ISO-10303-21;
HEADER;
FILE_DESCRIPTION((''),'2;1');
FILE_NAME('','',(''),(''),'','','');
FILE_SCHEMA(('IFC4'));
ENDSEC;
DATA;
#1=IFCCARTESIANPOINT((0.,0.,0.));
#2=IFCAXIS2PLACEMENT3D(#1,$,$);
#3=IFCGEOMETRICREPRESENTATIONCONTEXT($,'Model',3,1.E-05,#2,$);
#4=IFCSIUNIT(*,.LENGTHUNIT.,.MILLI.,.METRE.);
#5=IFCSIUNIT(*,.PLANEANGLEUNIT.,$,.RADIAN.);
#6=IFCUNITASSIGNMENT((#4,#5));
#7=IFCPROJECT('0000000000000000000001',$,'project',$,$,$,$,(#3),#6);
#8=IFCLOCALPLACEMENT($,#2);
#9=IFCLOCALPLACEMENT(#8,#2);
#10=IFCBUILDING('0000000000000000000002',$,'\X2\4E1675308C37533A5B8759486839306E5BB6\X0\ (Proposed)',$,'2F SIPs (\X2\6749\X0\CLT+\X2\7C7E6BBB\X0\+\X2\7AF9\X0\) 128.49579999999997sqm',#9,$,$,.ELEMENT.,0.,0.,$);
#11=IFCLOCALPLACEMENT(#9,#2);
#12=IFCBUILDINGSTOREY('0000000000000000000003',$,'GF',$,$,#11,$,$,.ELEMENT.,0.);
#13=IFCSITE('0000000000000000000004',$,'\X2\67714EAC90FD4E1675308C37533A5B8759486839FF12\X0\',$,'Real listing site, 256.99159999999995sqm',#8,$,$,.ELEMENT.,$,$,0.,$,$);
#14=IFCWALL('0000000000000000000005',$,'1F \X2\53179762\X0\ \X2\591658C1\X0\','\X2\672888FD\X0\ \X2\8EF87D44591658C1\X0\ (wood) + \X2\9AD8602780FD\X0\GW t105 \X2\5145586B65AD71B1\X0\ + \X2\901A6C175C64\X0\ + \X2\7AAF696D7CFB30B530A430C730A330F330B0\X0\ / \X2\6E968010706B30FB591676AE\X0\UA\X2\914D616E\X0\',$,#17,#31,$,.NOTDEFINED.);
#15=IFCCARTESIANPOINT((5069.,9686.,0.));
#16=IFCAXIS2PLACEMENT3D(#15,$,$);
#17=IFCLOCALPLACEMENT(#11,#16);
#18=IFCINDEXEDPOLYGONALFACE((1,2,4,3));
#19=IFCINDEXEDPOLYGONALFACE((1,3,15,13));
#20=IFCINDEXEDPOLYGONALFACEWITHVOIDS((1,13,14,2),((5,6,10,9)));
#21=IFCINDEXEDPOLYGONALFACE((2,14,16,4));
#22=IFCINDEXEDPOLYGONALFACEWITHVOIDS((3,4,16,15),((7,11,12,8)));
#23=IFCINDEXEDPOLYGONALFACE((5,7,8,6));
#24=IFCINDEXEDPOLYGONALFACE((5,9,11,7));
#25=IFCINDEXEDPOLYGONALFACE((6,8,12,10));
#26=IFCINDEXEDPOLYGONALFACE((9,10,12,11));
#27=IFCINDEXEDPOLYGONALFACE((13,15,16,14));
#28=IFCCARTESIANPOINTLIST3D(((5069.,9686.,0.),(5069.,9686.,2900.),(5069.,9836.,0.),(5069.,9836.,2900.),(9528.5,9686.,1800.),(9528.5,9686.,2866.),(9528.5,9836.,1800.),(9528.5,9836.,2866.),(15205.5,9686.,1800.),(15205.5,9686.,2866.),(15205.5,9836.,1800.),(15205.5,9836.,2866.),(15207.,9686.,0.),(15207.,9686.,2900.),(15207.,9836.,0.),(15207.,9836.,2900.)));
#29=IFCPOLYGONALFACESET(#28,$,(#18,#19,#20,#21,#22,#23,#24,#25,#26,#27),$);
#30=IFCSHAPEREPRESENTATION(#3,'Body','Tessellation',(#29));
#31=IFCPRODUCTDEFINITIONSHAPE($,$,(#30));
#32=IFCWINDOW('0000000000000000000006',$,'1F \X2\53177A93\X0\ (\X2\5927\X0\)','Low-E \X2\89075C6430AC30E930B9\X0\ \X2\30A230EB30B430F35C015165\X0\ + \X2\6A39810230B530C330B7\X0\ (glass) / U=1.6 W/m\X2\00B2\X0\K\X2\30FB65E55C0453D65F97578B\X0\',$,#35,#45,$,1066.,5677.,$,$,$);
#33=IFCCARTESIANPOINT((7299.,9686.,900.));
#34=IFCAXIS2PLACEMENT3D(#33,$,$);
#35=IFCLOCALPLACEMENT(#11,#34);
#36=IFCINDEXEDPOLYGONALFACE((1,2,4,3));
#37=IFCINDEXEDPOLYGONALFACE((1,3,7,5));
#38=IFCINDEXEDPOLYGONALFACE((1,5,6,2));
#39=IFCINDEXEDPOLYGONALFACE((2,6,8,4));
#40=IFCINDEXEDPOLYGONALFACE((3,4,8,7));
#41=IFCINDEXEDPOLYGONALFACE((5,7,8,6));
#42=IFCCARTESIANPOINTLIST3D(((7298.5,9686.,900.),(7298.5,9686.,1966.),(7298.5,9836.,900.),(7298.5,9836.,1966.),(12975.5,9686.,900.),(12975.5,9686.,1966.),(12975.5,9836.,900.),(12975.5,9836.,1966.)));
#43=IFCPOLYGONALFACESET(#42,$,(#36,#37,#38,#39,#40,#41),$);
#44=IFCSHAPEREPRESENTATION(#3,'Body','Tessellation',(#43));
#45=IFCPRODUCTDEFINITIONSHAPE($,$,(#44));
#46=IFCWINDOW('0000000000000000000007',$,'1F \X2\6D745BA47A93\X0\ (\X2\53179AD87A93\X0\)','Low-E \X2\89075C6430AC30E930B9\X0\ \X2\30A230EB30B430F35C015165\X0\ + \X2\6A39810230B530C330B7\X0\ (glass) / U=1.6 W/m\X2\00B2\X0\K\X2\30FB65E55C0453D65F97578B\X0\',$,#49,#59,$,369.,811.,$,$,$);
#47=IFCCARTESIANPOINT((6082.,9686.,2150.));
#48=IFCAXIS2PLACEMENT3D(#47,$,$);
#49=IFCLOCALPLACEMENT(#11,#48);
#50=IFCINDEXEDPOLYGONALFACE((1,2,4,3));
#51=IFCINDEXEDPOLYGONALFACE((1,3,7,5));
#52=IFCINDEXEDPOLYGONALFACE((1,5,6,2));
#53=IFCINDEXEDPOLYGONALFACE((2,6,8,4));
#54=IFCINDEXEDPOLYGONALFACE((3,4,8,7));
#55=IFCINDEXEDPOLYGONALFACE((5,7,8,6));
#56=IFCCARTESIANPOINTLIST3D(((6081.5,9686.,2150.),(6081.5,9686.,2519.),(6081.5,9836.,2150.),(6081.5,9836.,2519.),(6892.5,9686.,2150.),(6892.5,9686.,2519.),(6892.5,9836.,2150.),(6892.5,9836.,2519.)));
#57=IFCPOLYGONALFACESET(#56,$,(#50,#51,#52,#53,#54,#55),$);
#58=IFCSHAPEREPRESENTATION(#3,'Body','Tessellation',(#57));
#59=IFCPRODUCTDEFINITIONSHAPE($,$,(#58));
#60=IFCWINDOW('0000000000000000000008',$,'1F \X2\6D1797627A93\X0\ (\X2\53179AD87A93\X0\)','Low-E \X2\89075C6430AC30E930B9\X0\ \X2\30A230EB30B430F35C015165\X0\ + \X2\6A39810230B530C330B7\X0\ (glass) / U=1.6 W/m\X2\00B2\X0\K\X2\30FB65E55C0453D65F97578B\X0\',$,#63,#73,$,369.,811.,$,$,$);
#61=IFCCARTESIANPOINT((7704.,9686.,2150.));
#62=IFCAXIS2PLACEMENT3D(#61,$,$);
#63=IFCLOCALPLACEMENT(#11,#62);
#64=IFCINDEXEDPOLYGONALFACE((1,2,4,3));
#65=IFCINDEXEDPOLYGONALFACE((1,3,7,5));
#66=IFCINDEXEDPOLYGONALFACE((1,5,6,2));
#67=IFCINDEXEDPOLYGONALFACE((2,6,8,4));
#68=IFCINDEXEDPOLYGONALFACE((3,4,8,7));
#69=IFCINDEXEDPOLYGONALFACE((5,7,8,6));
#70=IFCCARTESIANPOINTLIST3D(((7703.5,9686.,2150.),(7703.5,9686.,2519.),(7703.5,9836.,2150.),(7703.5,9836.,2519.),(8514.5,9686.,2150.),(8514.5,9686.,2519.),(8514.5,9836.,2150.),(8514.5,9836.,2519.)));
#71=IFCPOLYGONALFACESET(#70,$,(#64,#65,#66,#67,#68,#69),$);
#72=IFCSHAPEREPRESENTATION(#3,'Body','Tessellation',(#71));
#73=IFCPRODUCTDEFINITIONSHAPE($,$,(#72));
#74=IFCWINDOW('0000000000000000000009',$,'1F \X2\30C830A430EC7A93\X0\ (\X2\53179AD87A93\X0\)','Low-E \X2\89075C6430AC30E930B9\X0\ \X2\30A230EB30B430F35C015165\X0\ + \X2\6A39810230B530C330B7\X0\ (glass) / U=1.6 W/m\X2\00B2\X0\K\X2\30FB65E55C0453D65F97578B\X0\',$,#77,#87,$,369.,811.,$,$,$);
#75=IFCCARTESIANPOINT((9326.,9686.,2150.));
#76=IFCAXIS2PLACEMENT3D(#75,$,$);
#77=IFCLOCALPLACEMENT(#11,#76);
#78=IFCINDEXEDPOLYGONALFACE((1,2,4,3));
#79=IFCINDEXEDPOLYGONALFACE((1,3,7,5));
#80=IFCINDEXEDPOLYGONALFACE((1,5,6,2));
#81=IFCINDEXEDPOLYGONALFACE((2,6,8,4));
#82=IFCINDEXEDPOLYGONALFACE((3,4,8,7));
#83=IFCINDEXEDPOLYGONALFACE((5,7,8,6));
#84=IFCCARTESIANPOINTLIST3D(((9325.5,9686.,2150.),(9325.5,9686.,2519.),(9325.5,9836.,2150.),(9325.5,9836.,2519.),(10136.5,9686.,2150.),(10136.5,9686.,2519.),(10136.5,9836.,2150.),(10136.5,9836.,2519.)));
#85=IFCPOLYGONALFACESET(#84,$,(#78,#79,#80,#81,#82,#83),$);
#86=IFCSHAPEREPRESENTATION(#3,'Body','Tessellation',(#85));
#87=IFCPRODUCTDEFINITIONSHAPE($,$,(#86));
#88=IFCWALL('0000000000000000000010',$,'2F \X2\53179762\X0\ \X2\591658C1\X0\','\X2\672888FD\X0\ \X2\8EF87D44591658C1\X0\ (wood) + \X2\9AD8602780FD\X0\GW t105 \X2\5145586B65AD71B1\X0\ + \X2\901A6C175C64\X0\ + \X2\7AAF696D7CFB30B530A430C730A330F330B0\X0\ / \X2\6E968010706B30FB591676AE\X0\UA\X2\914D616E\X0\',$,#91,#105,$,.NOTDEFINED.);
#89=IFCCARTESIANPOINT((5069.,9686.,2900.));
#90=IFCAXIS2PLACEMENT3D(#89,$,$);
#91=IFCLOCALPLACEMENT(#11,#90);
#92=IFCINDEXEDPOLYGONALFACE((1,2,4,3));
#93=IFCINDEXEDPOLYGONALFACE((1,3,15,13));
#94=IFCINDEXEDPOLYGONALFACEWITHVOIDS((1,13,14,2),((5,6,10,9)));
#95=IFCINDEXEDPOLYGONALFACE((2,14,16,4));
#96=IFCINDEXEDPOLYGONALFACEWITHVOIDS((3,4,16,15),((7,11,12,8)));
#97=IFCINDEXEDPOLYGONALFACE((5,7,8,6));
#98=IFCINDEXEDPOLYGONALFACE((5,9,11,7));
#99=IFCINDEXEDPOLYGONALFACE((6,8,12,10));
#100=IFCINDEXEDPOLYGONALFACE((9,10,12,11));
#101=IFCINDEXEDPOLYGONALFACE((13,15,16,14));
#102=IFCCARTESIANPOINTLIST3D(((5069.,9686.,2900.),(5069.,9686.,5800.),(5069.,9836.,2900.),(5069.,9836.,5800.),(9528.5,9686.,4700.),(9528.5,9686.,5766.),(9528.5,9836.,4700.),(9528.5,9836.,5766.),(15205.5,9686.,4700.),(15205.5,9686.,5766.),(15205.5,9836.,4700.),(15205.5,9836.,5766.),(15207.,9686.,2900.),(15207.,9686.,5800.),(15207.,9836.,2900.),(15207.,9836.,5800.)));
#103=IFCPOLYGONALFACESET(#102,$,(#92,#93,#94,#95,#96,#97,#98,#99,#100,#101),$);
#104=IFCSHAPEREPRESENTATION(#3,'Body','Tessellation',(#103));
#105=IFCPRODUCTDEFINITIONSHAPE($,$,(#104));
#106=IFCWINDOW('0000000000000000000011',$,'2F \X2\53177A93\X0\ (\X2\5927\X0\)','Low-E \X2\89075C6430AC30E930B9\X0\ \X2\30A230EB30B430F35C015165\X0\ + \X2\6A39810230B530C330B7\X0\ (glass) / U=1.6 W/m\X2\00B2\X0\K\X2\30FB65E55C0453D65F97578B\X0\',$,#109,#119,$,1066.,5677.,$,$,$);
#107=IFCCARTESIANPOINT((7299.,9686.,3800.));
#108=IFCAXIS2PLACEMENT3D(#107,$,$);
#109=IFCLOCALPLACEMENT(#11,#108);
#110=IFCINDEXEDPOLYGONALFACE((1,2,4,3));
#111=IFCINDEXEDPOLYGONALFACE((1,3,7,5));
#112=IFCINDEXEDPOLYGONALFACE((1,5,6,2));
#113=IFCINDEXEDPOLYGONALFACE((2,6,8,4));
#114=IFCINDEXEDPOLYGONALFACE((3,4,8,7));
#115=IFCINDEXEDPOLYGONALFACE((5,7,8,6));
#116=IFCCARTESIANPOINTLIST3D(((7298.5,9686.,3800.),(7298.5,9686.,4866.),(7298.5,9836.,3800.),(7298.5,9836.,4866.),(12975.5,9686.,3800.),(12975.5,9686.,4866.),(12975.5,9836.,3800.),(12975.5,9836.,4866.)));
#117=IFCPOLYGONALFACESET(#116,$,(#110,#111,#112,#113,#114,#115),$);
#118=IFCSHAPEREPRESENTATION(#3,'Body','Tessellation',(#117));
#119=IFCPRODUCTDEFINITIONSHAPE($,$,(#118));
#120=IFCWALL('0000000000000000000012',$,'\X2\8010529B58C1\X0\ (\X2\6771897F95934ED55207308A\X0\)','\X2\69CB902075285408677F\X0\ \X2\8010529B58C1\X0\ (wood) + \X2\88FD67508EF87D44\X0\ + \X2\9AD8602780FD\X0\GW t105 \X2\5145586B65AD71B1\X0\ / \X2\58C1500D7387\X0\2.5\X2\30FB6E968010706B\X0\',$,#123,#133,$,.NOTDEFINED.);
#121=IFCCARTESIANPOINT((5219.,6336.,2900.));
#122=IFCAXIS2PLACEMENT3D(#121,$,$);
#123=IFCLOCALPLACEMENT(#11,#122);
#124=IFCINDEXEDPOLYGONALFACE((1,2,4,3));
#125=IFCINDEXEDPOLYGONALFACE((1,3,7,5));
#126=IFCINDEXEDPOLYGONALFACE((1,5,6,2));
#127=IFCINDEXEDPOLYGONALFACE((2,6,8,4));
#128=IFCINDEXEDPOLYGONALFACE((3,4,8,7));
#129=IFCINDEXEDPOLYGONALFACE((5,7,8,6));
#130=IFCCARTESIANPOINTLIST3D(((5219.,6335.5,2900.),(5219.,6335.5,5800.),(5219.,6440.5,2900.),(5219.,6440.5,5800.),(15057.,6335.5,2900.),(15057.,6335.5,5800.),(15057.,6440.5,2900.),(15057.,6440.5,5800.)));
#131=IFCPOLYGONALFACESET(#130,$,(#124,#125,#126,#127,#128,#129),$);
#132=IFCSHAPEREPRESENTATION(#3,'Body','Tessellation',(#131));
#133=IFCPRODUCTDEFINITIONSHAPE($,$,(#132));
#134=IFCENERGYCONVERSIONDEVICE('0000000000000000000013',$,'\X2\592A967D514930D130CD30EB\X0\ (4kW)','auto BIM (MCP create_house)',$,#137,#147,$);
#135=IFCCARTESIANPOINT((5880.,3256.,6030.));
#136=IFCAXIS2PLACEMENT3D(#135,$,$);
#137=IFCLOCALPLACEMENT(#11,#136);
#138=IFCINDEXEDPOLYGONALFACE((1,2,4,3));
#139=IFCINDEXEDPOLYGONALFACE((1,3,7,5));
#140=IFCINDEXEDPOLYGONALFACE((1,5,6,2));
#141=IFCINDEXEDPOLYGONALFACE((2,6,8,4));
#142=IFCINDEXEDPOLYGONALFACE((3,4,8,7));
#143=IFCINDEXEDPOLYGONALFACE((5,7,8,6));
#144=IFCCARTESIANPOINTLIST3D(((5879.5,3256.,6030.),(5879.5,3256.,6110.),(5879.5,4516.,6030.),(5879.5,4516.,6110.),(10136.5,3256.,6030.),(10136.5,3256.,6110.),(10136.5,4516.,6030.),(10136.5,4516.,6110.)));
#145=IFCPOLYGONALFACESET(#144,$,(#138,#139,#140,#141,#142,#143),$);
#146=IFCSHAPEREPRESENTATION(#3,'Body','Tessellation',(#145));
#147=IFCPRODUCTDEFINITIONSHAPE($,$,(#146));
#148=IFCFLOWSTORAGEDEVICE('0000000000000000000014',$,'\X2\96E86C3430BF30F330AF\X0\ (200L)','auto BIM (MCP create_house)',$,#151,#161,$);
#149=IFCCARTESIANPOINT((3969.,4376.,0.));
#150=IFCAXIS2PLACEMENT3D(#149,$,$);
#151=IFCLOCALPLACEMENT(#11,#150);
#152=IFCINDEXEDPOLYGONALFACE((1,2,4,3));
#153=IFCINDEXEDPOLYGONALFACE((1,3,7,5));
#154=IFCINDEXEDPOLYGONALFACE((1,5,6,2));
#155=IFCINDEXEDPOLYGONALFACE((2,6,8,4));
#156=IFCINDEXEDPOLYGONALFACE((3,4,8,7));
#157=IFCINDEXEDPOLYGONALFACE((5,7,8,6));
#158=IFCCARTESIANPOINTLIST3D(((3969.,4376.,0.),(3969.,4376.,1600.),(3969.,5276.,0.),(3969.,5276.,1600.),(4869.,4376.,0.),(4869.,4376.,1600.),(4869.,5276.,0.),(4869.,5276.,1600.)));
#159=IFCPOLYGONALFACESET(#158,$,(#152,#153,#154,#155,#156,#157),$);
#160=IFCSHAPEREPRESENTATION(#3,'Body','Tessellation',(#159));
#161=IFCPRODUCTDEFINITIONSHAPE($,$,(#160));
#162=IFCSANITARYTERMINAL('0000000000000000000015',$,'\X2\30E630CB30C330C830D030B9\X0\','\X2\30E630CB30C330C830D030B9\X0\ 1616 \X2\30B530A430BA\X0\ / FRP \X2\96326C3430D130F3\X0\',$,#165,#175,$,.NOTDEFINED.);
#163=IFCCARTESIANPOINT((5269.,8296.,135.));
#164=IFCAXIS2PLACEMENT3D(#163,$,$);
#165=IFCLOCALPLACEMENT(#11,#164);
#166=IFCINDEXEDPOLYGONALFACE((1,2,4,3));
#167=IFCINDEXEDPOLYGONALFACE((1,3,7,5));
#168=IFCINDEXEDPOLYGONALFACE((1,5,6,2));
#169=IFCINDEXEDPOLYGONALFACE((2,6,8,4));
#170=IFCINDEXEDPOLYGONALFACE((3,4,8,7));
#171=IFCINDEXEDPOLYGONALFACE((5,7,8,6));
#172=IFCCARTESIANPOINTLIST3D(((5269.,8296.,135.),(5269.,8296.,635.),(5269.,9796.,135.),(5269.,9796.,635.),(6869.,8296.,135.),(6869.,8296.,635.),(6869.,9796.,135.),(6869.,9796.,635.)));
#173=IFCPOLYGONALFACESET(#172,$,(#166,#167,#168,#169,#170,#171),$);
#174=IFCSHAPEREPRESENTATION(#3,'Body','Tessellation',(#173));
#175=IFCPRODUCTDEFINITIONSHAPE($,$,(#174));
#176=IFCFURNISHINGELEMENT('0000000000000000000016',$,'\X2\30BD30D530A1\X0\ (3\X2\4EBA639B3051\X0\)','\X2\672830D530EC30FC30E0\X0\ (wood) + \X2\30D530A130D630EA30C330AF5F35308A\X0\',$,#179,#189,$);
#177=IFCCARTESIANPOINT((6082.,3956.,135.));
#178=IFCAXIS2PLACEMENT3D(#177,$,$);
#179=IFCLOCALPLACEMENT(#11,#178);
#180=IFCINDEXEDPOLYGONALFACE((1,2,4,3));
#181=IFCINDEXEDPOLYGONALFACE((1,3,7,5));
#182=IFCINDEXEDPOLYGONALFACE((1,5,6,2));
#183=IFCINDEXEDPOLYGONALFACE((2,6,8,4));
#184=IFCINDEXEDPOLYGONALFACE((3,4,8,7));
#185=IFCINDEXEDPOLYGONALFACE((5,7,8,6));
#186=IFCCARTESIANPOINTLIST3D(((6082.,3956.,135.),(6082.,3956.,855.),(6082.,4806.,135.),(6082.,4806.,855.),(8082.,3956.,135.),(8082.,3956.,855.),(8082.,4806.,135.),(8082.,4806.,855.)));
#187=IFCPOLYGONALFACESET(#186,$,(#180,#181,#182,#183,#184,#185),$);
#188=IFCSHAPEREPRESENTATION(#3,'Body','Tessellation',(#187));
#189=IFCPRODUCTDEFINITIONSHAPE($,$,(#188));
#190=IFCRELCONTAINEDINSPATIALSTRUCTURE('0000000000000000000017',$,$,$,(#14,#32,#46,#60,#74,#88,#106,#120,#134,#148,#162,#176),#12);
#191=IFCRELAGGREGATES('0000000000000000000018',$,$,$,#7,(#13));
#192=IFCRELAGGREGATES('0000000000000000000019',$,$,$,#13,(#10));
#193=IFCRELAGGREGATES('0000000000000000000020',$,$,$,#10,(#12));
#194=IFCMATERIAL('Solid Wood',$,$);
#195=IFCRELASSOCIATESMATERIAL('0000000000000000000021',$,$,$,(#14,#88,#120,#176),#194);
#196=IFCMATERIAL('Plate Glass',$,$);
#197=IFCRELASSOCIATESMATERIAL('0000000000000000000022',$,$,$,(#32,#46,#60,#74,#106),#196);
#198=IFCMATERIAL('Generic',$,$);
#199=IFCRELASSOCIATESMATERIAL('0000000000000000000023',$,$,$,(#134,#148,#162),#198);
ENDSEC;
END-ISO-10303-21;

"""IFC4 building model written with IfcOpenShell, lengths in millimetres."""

from ifc_helpers import new_model, si_unit, frame, frame_2d, origin, place, context, project, spatial, rectangle, extrude, material, element, fill, save


model = new_model("IFC4")

# Units and contexts
model_context = context("Model", 3, precision=1e-05, world=origin())
ifc_project = project(units=[si_unit("LENGTHUNIT", "METRE", prefix="MILLI"), si_unit("PLANEANGLEUNIT", "RADIAN")], contexts=[model_context])

# Site, building, storey
site_placement = place(None, origin())
site = spatial("IfcSite", under=ifc_project, at=site_placement, Name="東京都世田谷区宇奈根２", ObjectType="Real listing site, 256.99159999999995sqm", CompositionType="ELEMENT", RefElevation=0.0)
building_placement = place(site_placement, origin())
building = spatial("IfcBuilding", under=site, at=building_placement, Name="世田谷区宇奈根の家 (Proposed)", ObjectType="2F SIPs (杉CLT+籾殻+竹) 128.49579999999997sqm", CompositionType="ELEMENT", ElevationOfRefHeight=0.0, ElevationOfTerrain=0.0)
storey_placement = place(building_placement, origin())
storey = spatial("IfcBuildingStorey", under=building, at=storey_placement, Name="GF", CompositionType="ELEMENT", Elevation=0.0)

# Wall, openings, windows
ifc_material_1 = material(Name="Solid Wood")
wall_1_placement = place(storey_placement, frame((5069.0, 9686.0, 0.0)))
wall_1 = element("IfcWall", 1, at=wall_1_placement, inside=storey, material=ifc_material_1, Name="1F 北面 外壁", Description="木製 軸組外壁 (wood) + 高性能GW t105 充填断熱 + 通気層 + 窯業系サイディング / 準耐火・外皮UA配慮", PredefinedType="NOTDEFINED", context=model_context, shape_type="SweptSolid", body=[
    extrude(rectangle(XDim=10138.0, YDim=150.0, at=frame_2d((5069.0, 75.0))), frame((5069.0, 9686.0, 0.0)), (0.0, 0.0, 1.0), 2900.0),
])
opening_1_placement = place(storey_placement, frame((7299.0, 9686.0, 900.0)))
opening_1 = element("IfcOpeningElement", 2, at=opening_1_placement, cuts=wall_1, PredefinedType="NOTDEFINED", context=model_context, shape_type="SweptSolid", body=[
    extrude(rectangle(XDim=5677.0, YDim=150.0, at=frame_2d((2838.0, 75.0))), frame((7299.0, 9686.0, 900.0)), (0.0, 0.0, 1.0), 1066.0),
])
opening_2_placement = place(storey_placement, frame((6082.0, 9686.0, 2150.0)))
opening_2 = element("IfcOpeningElement", 3, at=opening_2_placement, cuts=wall_1, PredefinedType="NOTDEFINED", context=model_context, shape_type="SweptSolid", body=[
    extrude(rectangle(XDim=811.0, YDim=150.0, at=frame_2d((405.0, 75.0))), frame((6082.0, 9686.0, 2150.0)), (0.0, 0.0, 1.0), 369.0),
])
opening_3_placement = place(storey_placement, frame((7704.0, 9686.0, 2150.0)))
opening_3 = element("IfcOpeningElement", 4, at=opening_3_placement, cuts=wall_1, PredefinedType="NOTDEFINED", context=model_context, shape_type="SweptSolid", body=[
    extrude(rectangle(XDim=811.0, YDim=150.0, at=frame_2d((405.0, 75.0))), frame((7704.0, 9686.0, 2150.0)), (0.0, 0.0, 1.0), 369.0),
])
opening_4_placement = place(storey_placement, frame((9326.0, 9686.0, 2150.0)))
opening_4 = element("IfcOpeningElement", 5, at=opening_4_placement, cuts=wall_1, PredefinedType="NOTDEFINED", context=model_context, shape_type="SweptSolid", body=[
    extrude(rectangle(XDim=811.0, YDim=150.0, at=frame_2d((405.0, 75.0))), frame((9326.0, 9686.0, 2150.0)), (0.0, 0.0, 1.0), 369.0),
])
ifc_material_2 = material(Name="Plate Glass")
window_1_placement = place(storey_placement, frame((7299.0, 9686.0, 900.0)))
window_1 = element("IfcWindow", 6, at=window_1_placement, inside=storey, material=ifc_material_2, Name="1F 北窓 (大)", Description="Low-E 複層ガラス アルゴン封入 + 樹脂サッシ (glass) / U=1.6 W/m²K・日射取得型", OverallHeight=1066.0, OverallWidth=5677.0, context=model_context, shape_type="SweptSolid", body=[
    extrude(rectangle(XDim=5677.0, YDim=150.0, at=frame_2d((2838.0, 75.0))), frame((7299.0, 9686.0, 900.0)), (0.0, 0.0, 1.0), 1066.0),
])
fill(opening_1, window_1)
window_2_placement = place(storey_placement, frame((6082.0, 9686.0, 2150.0)))
window_2 = element("IfcWindow", 7, at=window_2_placement, inside=storey, material=ifc_material_2, Name="1F 浴室窓 (北高窓)", Description="Low-E 複層ガラス アルゴン封入 + 樹脂サッシ (glass) / U=1.6 W/m²K・日射取得型", OverallHeight=369.0, OverallWidth=811.0, context=model_context, shape_type="SweptSolid", body=[
    extrude(rectangle(XDim=811.0, YDim=150.0, at=frame_2d((405.0, 75.0))), frame((6082.0, 9686.0, 2150.0)), (0.0, 0.0, 1.0), 369.0),
])
fill(opening_2, window_2)
window_3_placement = place(storey_placement, frame((7704.0, 9686.0, 2150.0)))
window_3 = element("IfcWindow", 8, at=window_3_placement, inside=storey, material=ifc_material_2, Name="1F 洗面窓 (北高窓)", Description="Low-E 複層ガラス アルゴン封入 + 樹脂サッシ (glass) / U=1.6 W/m²K・日射取得型", OverallHeight=369.0, OverallWidth=811.0, context=model_context, shape_type="SweptSolid", body=[
    extrude(rectangle(XDim=811.0, YDim=150.0, at=frame_2d((405.0, 75.0))), frame((7704.0, 9686.0, 2150.0)), (0.0, 0.0, 1.0), 369.0),
])
fill(opening_3, window_3)
window_4_placement = place(storey_placement, frame((9326.0, 9686.0, 2150.0)))
window_4 = element("IfcWindow", 9, at=window_4_placement, inside=storey, material=ifc_material_2, Name="1F トイレ窓 (北高窓)", Description="Low-E 複層ガラス アルゴン封入 + 樹脂サッシ (glass) / U=1.6 W/m²K・日射取得型", OverallHeight=369.0, OverallWidth=811.0, context=model_context, shape_type="SweptSolid", body=[
    extrude(rectangle(XDim=811.0, YDim=150.0, at=frame_2d((405.0, 75.0))), frame((9326.0, 9686.0, 2150.0)), (0.0, 0.0, 1.0), 369.0),
])
fill(opening_4, window_4)

# Wall, opening, window
wall_2_placement = place(storey_placement, frame((5069.0, 9686.0, 2900.0)))
wall_2 = element("IfcWall", 10, at=wall_2_placement, inside=storey, material=ifc_material_1, Name="2F 北面 外壁", Description="木製 軸組外壁 (wood) + 高性能GW t105 充填断熱 + 通気層 + 窯業系サイディング / 準耐火・外皮UA配慮", PredefinedType="NOTDEFINED", context=model_context, shape_type="SweptSolid", body=[
    extrude(rectangle(XDim=10138.0, YDim=150.0, at=frame_2d((5069.0, 75.0))), frame((5069.0, 9686.0, 2900.0)), (0.0, 0.0, 1.0), 2900.0),
])
opening_5_placement = place(storey_placement, frame((7299.0, 9686.0, 3800.0)))
opening_5 = element("IfcOpeningElement", 11, at=opening_5_placement, cuts=wall_2, PredefinedType="NOTDEFINED", context=model_context, shape_type="SweptSolid", body=[
    extrude(rectangle(XDim=5677.0, YDim=150.0, at=frame_2d((2838.0, 75.0))), frame((7299.0, 9686.0, 3800.0)), (0.0, 0.0, 1.0), 1066.0),
])
window_5_placement = place(storey_placement, frame((7299.0, 9686.0, 3800.0)))
window_5 = element("IfcWindow", 12, at=window_5_placement, inside=storey, material=ifc_material_2, Name="2F 北窓 (大)", Description="Low-E 複層ガラス アルゴン封入 + 樹脂サッシ (glass) / U=1.6 W/m²K・日射取得型", OverallHeight=1066.0, OverallWidth=5677.0, context=model_context, shape_type="SweptSolid", body=[
    extrude(rectangle(XDim=5677.0, YDim=150.0, at=frame_2d((2838.0, 75.0))), frame((7299.0, 9686.0, 3800.0)), (0.0, 0.0, 1.0), 1066.0),
])
fill(opening_5, window_5)

# Wall
wall_3_placement = place(storey_placement, frame((5219.0, 6336.0, 2900.0)))
element("IfcWall", 13, at=wall_3_placement, inside=storey, material=ifc_material_1, Name="耐力壁 (東西間仕切り)", Description="構造用合板 耐力壁 (wood) + 製材軸組 + 高性能GW t105 充填断熱 / 壁倍率2.5・準耐火", PredefinedType="NOTDEFINED", context=model_context, shape_type="SweptSolid", body=[
    extrude(rectangle(XDim=9838.0, YDim=105.0, at=frame_2d((4919.0, 52.0))), frame((5219.0, 6336.0, 2900.0)), (0.0, 0.0, 1.0), 2900.0),
])

# Energy conversion device
ifc_material_3 = material(Name="Generic")
energy_conversion_device_placement = place(storey_placement, frame((5880.0, 3256.0, 6030.0)))
element("IfcEnergyConversionDevice", 14, at=energy_conversion_device_placement, inside=storey, material=ifc_material_3, Name="太陽光パネル (4kW)", Description="auto BIM (MCP create_house)", context=model_context, shape_type="SweptSolid", body=[
    extrude(rectangle(XDim=4257.0, YDim=1260.0, at=frame_2d((2128.0, 630.0))), frame((5880.0, 3256.0, 6030.0)), (0.0, 0.0, 1.0), 80.0),
])

# Flow storage device
flow_storage_device_placement = place(storey_placement, frame((3969.0, 4376.0, 0.0)))
element("IfcFlowStorageDevice", 15, at=flow_storage_device_placement, inside=storey, material=ifc_material_3, Name="雨水タンク (200L)", Description="auto BIM (MCP create_house)", context=model_context, shape_type="SweptSolid", body=[
    extrude(rectangle(XDim=900.0, YDim=900.0, at=frame_2d((450.0, 450.0))), frame((3969.0, 4376.0, 0.0)), (0.0, 0.0, 1.0), 1600.0),
])

# Sanitary terminal
sanitary_terminal_placement = place(storey_placement, frame((5269.0, 8296.0, 135.0)))
element("IfcSanitaryTerminal", 16, at=sanitary_terminal_placement, inside=storey, material=ifc_material_3, Name="ユニットバス", Description="ユニットバス 1616 サイズ / FRP 防水パン", PredefinedType="NOTDEFINED", context=model_context, shape_type="SweptSolid", body=[
    extrude(rectangle(XDim=1600.0, YDim=1500.0, at=frame_2d((800.0, 750.0))), frame((5269.0, 8296.0, 135.0)), (0.0, 0.0, 1.0), 500.0),
])

# Furnishing element
furnishing_1_placement = place(storey_placement, frame((6082.0, 3956.0, 135.0)))
element("IfcFurnishingElement", 17, at=furnishing_1_placement, inside=storey, material=ifc_material_1, Name="ソファ (3人掛け)", Description="木フレーム (wood) + ファブリック張り", context=model_context, shape_type="SweptSolid", body=[
    extrude(rectangle(XDim=2000.0, YDim=850.0, at=frame_2d((1000.0, 425.0))), frame((6082.0, 3956.0, 135.0)), (0.0, 0.0, 1.0), 720.0),
])

save(model, "model.ifc")
